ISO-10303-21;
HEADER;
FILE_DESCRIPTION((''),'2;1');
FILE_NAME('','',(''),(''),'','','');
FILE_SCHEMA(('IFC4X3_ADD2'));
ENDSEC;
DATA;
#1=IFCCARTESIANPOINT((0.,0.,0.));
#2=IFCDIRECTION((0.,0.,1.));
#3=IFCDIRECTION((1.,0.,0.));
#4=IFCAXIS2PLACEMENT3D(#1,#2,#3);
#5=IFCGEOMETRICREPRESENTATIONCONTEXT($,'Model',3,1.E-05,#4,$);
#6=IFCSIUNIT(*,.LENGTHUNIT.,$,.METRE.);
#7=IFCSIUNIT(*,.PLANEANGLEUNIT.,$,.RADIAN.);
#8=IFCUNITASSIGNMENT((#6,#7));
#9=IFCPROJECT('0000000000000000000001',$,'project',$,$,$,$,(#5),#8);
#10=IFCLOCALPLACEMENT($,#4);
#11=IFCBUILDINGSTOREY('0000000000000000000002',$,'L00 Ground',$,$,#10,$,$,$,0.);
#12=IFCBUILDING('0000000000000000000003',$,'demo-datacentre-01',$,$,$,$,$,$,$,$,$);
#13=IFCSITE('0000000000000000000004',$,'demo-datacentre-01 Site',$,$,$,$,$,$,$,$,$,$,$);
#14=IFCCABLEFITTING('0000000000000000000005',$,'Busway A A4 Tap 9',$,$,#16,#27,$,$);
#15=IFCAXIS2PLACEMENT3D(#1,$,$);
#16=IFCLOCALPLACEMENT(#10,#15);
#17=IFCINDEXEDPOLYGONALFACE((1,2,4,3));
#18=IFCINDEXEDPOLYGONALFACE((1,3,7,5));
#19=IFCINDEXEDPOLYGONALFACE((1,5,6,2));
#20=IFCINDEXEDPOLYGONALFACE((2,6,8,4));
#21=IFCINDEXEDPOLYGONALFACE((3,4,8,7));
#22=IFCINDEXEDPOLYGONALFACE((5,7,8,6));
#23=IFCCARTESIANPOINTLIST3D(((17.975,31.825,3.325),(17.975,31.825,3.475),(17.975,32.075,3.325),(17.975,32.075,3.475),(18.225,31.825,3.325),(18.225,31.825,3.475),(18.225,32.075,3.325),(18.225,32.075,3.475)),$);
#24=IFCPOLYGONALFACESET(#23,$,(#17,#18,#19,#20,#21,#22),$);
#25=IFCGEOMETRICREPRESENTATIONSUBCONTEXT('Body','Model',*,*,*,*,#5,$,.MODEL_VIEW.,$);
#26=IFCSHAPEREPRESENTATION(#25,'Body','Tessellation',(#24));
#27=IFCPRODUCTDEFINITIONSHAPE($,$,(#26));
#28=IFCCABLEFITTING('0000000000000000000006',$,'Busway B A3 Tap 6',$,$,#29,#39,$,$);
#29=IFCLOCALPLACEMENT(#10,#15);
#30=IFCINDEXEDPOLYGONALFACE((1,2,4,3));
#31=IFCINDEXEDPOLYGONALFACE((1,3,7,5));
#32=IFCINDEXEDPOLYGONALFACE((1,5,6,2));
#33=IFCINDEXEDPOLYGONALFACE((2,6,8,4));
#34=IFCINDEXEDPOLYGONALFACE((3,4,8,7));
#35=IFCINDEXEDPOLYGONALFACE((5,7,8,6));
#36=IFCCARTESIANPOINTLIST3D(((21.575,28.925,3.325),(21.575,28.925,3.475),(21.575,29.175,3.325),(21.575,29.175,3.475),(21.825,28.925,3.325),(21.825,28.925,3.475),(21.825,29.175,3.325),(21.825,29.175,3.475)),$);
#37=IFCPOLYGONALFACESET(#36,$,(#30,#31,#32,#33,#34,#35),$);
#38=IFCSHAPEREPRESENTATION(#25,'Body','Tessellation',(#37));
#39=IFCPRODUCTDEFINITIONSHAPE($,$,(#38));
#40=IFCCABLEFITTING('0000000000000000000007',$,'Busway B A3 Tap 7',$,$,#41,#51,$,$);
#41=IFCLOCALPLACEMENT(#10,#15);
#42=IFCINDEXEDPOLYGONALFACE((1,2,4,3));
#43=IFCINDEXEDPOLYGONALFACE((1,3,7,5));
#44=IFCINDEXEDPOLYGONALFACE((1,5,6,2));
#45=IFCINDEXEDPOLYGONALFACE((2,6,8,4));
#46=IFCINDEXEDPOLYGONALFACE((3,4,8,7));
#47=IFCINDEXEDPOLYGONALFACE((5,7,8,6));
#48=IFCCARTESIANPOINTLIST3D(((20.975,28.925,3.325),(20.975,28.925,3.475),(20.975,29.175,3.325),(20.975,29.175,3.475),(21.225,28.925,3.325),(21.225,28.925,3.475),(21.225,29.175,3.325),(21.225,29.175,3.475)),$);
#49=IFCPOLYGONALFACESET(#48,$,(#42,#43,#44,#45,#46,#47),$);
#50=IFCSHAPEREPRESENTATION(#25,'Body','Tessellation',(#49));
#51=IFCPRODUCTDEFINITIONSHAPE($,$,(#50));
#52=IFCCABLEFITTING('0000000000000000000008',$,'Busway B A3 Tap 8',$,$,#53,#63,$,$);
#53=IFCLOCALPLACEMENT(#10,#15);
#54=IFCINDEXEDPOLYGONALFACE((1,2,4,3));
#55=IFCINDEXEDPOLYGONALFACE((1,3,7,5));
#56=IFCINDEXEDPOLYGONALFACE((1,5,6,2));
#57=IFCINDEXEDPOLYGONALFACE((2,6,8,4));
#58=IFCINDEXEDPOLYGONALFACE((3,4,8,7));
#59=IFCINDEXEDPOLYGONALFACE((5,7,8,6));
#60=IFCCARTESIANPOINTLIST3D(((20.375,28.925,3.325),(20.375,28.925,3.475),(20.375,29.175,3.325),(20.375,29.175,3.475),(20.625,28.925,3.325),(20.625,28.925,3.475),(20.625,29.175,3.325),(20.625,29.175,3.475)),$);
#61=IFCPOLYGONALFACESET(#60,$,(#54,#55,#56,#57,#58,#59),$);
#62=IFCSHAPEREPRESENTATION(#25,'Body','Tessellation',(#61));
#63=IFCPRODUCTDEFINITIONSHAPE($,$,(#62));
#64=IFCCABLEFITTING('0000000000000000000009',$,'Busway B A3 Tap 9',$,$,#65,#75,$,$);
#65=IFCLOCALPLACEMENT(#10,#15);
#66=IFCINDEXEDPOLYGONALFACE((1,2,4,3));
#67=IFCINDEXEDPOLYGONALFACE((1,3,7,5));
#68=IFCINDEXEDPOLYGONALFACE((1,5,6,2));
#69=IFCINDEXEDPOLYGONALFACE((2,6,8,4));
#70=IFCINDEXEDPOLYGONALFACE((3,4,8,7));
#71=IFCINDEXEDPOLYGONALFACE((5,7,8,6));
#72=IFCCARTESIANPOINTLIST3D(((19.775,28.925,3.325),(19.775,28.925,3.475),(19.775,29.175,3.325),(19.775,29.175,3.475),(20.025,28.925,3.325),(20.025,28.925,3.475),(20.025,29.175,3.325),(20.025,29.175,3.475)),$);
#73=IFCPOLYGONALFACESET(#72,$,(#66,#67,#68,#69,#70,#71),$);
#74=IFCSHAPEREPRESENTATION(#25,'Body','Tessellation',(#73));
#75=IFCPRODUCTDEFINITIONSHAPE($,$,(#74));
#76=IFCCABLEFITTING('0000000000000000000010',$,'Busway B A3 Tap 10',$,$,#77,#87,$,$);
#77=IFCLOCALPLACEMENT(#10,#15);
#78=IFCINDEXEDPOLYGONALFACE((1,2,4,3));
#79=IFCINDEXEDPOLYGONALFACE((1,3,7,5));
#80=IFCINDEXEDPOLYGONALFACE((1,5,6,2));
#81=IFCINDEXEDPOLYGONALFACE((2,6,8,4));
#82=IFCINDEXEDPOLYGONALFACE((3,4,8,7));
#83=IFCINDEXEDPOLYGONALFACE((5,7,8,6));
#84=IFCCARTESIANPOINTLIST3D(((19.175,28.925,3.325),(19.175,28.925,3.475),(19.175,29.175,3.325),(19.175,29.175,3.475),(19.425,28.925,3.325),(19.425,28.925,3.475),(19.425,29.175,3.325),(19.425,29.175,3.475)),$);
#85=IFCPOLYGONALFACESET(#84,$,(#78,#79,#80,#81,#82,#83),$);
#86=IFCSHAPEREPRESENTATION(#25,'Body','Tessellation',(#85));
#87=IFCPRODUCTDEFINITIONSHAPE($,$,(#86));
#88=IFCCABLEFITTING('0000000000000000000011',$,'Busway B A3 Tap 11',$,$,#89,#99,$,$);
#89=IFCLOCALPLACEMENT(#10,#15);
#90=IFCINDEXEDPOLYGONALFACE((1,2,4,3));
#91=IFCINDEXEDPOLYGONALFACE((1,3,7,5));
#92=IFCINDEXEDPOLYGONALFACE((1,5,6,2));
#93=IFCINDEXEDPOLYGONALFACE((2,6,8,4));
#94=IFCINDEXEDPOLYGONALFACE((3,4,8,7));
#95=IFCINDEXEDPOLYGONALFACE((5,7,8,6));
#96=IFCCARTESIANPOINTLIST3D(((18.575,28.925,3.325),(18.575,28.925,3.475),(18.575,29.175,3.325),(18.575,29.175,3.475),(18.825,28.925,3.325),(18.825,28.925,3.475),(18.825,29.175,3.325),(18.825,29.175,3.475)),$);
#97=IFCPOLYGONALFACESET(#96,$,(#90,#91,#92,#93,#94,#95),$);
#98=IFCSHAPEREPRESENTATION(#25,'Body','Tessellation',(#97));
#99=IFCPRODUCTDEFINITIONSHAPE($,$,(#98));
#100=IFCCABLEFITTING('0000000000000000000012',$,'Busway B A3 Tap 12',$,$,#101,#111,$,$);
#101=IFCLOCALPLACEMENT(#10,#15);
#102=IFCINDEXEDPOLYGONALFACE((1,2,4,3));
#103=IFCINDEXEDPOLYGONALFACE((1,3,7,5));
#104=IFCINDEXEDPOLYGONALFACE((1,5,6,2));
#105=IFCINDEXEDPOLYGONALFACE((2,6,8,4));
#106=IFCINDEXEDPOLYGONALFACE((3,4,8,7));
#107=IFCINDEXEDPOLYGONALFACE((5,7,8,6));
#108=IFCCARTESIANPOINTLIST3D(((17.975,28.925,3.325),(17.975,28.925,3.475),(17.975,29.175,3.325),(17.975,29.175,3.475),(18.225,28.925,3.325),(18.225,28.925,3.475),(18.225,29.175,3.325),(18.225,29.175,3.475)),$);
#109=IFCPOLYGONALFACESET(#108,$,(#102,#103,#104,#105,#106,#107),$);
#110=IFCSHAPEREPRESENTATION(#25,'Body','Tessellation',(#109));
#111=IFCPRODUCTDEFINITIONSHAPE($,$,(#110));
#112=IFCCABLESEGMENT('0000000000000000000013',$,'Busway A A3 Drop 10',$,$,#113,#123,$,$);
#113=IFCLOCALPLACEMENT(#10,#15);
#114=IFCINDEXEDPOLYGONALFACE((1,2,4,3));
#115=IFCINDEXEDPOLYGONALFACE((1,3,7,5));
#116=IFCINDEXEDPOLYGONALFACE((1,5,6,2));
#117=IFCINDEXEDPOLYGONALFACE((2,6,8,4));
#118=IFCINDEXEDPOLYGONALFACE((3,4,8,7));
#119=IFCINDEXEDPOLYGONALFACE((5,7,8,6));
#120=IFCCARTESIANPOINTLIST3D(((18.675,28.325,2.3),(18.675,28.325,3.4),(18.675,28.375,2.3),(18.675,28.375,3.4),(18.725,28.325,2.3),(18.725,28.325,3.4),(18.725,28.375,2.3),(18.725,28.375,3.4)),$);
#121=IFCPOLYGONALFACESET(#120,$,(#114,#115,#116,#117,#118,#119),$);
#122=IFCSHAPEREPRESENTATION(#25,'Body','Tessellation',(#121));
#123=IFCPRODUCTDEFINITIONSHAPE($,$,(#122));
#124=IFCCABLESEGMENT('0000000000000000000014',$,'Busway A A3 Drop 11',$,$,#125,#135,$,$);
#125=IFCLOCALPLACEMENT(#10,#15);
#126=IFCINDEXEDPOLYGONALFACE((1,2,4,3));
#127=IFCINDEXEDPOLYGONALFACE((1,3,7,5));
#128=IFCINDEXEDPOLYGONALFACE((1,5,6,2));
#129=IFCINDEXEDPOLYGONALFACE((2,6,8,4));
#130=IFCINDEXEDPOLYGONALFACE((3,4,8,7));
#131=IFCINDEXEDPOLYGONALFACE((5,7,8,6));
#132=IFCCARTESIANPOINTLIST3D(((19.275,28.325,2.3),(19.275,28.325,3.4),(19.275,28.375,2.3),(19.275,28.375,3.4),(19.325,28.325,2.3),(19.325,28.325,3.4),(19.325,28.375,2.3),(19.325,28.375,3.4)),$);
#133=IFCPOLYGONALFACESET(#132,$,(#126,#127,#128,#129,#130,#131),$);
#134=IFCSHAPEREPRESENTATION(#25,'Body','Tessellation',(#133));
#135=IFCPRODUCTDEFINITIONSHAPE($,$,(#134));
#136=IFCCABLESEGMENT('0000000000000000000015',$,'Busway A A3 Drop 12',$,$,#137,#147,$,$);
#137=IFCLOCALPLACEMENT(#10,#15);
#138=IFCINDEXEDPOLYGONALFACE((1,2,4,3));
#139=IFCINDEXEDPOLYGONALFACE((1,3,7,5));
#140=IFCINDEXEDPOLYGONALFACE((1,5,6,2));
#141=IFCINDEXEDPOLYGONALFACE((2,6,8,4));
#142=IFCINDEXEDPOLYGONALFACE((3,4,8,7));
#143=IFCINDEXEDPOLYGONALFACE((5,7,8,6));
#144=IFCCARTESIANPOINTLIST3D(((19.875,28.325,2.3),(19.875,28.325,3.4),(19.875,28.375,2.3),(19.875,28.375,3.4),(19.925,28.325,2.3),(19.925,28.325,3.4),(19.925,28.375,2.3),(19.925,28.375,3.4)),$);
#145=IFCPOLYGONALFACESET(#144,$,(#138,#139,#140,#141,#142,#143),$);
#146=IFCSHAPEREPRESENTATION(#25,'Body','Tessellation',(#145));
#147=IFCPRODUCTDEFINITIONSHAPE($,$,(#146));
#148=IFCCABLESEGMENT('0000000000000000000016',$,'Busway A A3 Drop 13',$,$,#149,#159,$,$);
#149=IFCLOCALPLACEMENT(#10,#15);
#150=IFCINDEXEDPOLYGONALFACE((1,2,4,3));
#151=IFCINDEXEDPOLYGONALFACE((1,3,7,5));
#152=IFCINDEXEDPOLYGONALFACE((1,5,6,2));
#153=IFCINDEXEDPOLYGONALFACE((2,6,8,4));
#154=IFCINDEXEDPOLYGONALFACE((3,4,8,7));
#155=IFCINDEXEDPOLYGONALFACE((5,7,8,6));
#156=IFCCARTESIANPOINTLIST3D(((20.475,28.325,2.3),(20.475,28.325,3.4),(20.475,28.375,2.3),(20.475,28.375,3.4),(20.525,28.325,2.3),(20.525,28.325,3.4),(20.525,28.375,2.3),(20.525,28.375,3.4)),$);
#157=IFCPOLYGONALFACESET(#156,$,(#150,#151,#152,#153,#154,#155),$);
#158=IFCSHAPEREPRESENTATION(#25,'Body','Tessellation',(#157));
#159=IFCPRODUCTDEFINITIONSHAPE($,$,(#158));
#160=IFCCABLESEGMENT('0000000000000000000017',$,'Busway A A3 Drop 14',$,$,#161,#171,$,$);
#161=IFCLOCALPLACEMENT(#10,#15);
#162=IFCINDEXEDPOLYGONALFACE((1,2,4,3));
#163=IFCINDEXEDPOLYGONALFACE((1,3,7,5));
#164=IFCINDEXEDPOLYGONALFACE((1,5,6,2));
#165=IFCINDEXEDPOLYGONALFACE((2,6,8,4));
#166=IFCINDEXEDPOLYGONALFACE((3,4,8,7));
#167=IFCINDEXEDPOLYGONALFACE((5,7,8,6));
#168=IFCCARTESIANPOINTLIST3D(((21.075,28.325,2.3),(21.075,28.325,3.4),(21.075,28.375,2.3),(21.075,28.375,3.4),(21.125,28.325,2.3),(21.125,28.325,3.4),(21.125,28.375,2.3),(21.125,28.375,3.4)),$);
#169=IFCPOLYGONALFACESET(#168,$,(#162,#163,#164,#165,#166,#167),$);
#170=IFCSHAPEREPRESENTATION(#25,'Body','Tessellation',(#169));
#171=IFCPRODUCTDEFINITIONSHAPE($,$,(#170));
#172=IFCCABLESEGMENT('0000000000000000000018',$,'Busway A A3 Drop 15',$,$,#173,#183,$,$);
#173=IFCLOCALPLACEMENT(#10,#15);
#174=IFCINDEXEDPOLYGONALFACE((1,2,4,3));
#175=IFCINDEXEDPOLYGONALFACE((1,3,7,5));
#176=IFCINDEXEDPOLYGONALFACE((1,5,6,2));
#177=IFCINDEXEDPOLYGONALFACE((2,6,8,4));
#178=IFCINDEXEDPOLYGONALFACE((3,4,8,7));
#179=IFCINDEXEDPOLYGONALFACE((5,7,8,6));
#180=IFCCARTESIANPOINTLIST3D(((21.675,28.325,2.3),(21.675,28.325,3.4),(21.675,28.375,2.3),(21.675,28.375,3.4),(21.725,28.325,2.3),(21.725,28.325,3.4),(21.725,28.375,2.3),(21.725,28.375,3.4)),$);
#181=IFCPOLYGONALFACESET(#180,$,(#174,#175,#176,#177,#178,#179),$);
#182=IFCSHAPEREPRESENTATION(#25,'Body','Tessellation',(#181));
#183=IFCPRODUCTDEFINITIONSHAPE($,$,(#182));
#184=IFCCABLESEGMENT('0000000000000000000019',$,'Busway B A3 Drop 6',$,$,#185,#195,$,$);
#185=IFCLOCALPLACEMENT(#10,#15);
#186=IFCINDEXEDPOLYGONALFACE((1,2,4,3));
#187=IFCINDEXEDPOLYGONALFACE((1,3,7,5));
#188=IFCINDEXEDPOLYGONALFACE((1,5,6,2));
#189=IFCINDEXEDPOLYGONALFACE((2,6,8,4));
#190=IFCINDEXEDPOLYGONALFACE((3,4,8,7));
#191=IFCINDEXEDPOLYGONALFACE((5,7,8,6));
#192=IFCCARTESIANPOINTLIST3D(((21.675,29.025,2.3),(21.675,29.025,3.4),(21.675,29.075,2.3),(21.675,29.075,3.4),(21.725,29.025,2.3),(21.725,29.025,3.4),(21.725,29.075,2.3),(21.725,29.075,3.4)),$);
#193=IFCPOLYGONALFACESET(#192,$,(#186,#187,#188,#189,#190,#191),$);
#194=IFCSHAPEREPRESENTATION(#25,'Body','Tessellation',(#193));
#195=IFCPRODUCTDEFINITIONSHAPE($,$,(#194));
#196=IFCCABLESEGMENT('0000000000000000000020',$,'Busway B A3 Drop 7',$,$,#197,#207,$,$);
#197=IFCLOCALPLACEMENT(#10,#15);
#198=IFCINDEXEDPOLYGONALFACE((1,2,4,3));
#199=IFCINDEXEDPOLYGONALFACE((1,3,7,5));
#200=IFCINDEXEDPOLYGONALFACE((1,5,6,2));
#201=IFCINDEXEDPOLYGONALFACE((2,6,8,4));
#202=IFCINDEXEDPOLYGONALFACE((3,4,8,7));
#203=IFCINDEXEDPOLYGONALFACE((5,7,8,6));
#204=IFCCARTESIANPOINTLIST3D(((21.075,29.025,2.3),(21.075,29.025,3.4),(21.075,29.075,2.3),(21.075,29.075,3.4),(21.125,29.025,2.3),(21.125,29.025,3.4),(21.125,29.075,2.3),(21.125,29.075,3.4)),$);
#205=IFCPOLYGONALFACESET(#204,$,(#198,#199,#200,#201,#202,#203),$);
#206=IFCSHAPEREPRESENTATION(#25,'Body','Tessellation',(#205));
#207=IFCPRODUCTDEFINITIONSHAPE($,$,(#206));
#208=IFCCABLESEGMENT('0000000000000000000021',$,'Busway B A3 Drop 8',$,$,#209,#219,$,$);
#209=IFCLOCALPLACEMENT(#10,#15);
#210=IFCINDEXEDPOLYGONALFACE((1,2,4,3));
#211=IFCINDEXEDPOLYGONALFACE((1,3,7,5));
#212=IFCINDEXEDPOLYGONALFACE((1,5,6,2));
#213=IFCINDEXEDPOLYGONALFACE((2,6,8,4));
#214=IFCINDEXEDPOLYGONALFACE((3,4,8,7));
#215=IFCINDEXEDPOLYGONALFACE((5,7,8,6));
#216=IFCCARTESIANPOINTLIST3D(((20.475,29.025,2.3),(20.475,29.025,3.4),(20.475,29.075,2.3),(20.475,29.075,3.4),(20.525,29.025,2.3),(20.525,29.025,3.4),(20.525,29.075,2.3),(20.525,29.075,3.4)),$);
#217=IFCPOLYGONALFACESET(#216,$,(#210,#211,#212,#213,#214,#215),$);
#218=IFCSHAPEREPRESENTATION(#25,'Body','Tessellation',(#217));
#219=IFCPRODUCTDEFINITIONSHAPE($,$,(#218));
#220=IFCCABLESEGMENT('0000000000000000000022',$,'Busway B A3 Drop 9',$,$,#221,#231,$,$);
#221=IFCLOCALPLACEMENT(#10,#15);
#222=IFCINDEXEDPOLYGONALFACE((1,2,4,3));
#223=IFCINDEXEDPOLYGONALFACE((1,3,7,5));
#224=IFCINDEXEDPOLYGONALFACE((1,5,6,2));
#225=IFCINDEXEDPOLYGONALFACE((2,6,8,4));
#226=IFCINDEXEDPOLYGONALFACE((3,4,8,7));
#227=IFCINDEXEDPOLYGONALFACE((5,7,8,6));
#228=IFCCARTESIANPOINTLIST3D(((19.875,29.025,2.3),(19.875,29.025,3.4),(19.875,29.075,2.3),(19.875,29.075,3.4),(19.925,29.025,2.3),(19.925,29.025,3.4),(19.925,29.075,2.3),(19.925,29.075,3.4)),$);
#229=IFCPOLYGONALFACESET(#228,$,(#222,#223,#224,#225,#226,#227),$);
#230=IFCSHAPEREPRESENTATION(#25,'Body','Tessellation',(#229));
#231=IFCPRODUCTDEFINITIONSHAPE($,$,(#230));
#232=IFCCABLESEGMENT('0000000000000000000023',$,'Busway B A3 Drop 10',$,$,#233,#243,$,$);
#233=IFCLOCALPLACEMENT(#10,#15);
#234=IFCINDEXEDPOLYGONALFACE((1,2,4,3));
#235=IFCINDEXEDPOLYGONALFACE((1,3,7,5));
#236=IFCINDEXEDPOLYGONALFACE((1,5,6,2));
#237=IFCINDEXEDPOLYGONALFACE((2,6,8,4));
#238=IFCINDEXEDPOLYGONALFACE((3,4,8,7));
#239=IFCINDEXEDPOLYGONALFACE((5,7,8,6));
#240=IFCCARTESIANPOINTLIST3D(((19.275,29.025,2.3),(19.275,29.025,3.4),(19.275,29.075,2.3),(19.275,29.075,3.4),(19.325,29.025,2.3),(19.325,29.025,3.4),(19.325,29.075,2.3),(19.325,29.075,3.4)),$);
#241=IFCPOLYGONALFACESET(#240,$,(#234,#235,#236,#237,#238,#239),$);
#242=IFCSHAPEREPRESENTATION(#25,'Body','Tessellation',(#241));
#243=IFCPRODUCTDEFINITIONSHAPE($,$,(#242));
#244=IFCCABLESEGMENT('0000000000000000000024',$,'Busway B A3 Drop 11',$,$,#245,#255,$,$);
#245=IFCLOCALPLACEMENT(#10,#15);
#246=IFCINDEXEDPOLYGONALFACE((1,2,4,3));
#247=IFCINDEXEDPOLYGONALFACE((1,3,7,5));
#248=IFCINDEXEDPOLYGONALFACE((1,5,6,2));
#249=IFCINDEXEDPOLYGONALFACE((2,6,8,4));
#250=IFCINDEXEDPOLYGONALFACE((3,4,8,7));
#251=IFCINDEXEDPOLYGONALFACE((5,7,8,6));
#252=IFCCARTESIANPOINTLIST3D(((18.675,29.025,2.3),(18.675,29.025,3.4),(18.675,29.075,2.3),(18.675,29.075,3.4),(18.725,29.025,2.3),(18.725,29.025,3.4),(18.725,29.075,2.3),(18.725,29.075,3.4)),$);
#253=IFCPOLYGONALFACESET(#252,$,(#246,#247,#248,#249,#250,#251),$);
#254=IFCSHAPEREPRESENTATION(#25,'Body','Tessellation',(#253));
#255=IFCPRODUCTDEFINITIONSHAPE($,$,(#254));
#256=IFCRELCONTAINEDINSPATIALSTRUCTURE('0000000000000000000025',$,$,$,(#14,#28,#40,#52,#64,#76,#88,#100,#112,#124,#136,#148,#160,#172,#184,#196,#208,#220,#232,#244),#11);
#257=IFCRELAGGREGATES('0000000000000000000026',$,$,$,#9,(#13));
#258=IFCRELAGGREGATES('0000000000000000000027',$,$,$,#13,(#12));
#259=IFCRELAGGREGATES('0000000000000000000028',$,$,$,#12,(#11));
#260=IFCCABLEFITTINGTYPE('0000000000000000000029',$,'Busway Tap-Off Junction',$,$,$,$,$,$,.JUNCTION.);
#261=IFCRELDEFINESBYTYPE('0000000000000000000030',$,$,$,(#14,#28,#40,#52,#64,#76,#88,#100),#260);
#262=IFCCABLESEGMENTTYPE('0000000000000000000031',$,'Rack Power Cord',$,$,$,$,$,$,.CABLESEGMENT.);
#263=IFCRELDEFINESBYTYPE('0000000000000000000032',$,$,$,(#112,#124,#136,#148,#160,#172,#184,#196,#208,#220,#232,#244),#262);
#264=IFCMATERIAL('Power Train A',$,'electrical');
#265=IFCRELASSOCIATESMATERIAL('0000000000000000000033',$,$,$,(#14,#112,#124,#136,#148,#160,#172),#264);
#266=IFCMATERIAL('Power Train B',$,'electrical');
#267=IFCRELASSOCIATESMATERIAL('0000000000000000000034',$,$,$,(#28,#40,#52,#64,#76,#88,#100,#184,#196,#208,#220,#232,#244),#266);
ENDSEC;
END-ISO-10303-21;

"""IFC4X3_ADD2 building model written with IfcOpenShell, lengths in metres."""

from ifc_helpers import new_model, si_unit, frame, origin_with_axes, place, context, subcontext, project, spatial, rectangle, extrude, material, type_object, element, save


model = new_model("IFC4X3_ADD2")

# Units and contexts
model_context = context("Model", 3, precision=1e-05, world=origin_with_axes())
body_context = subcontext(model_context, "Body", "Model", "MODEL_VIEW")
ifc_project = project(units=[si_unit("LENGTHUNIT", "METRE"), si_unit("PLANEANGLEUNIT", "RADIAN")], contexts=[model_context])

# Site, building, storey
site = spatial("IfcSite", under=ifc_project, Name="demo-datacentre-01 Site")
building = spatial("IfcBuilding", under=site, Name="demo-datacentre-01")
storey_placement = place(None, origin_with_axes())
storey = spatial("IfcBuildingStorey", under=building, at=storey_placement, Name="L00 Ground", Elevation=0.0)

# Shared definitions
ifc_material_1 = material(Name="Power Train A", Category="electrical")
ifc_material_2 = material(Name="Power Train B", Category="electrical")

# Cable fittings
cable_fitting_type = type_object("IfcCableFittingType", Name="Busway Tap-Off Junction", PredefinedType="JUNCTION")
for number, where, z_axis, x_axis, name in (
    (1, (18.1, 31.95, 3.325), (0.0, 0.0, 1.0), (1.0, 0.0, 0.0), "Busway A A4 Tap 9"),
):
    element("IfcCableFitting", number, at=place(storey_placement, frame(where, z_axis=z_axis, x_axis=x_axis)), inside=storey, type_object=cable_fitting_type, material=ifc_material_1, Name=name, context=body_context, shape_type="SweptSolid", body=[
        extrude(rectangle(XDim=0.25, YDim=0.25), origin_with_axes(), (0.0, 0.0, 1.0), 0.15),
    ])
for number, where, z_axis, x_axis, name in (
    (2, (21.7, 29.05, 3.325), (0.0, 0.0, 1.0), (1.0, 0.0, 0.0), "Busway B A3 Tap 6"),
    (3, (21.1, 29.05, 3.325), (0.0, 0.0, 1.0), (1.0, 0.0, 0.0), "Busway B A3 Tap 7"),
    (4, (20.5, 29.05, 3.325), (0.0, 0.0, 1.0), (1.0, 0.0, 0.0), "Busway B A3 Tap 8"),
    (5, (19.9, 29.05, 3.325), (0.0, 0.0, 1.0), (1.0, 0.0, 0.0), "Busway B A3 Tap 9"),
    (6, (19.3, 29.05, 3.325), (0.0, 0.0, 1.0), (1.0, 0.0, 0.0), "Busway B A3 Tap 10"),
    (7, (18.7, 29.05, 3.325), (0.0, 0.0, 1.0), (1.0, 0.0, 0.0), "Busway B A3 Tap 11"),
    (8, (18.1, 29.05, 3.325), (0.0, 0.0, 1.0), (1.0, 0.0, 0.0), "Busway B A3 Tap 12"),
):
    element("IfcCableFitting", number, at=place(storey_placement, frame(where, z_axis=z_axis, x_axis=x_axis)), inside=storey, type_object=cable_fitting_type, material=ifc_material_2, Name=name, context=body_context, shape_type="SweptSolid", body=[
        extrude(rectangle(XDim=0.25, YDim=0.25), origin_with_axes(), (0.0, 0.0, 1.0), 0.15),
    ])

# Cable segments
cable_segment_type_1 = type_object("IfcCableSegmentType", Name="Rack Power Cord", PredefinedType="CABLESEGMENT")
for number, where, z_axis, x_axis, name in (
    (9, (18.7, 28.35, 3.4), (0.0, 0.0, -1.0), (1.0, 0.0, 0.0), "Busway A A3 Drop 10"),
    (10, (19.3, 28.35, 3.4), (0.0, 0.0, -1.0), (1.0, 0.0, 0.0), "Busway A A3 Drop 11"),
    (11, (19.9, 28.35, 3.4), (0.0, 0.0, -1.0), (1.0, 0.0, 0.0), "Busway A A3 Drop 12"),
    (12, (20.5, 28.35, 3.4), (0.0, 0.0, -1.0), (1.0, 0.0, 0.0), "Busway A A3 Drop 13"),
    (13, (21.1, 28.35, 3.4), (0.0, 0.0, -1.0), (1.0, 0.0, 0.0), "Busway A A3 Drop 14"),
    (14, (21.7, 28.35, 3.4), (0.0, 0.0, -1.0), (1.0, 0.0, 0.0), "Busway A A3 Drop 15"),
):
    element("IfcCableSegment", number, at=place(storey_placement, frame(where, z_axis=z_axis, x_axis=x_axis)), inside=storey, type_object=cable_segment_type_1, material=ifc_material_1, Name=name, context=body_context, shape_type="SweptSolid", body=[
        extrude(rectangle(XDim=0.05, YDim=0.05), origin_with_axes(), (0.0, 0.0, 1.0), 1.1),
    ])
for number, where, z_axis, x_axis, name in (
    (15, (21.7, 29.05, 3.4), (0.0, 0.0, -1.0), (1.0, 0.0, 0.0), "Busway B A3 Drop 6"),
    (16, (21.1, 29.05, 3.4), (0.0, 0.0, -1.0), (1.0, 0.0, 0.0), "Busway B A3 Drop 7"),
    (17, (20.5, 29.05, 3.4), (0.0, 0.0, -1.0), (1.0, 0.0, 0.0), "Busway B A3 Drop 8"),
    (18, (19.9, 29.05, 3.4), (0.0, 0.0, -1.0), (1.0, 0.0, 0.0), "Busway B A3 Drop 9"),
    (19, (19.3, 29.05, 3.4), (0.0, 0.0, -1.0), (1.0, 0.0, 0.0), "Busway B A3 Drop 10"),
    (20, (18.7, 29.05, 3.4), (0.0, 0.0, -1.0), (1.0, 0.0, 0.0), "Busway B A3 Drop 11"),
):
    element("IfcCableSegment", number, at=place(storey_placement, frame(where, z_axis=z_axis, x_axis=x_axis)), inside=storey, type_object=cable_segment_type_1, material=ifc_material_2, Name=name, context=body_context, shape_type="SweptSolid", body=[
        extrude(rectangle(XDim=0.05, YDim=0.05), origin_with_axes(), (0.0, 0.0, 1.0), 1.1),
    ])

save(model, "model.ifc")
